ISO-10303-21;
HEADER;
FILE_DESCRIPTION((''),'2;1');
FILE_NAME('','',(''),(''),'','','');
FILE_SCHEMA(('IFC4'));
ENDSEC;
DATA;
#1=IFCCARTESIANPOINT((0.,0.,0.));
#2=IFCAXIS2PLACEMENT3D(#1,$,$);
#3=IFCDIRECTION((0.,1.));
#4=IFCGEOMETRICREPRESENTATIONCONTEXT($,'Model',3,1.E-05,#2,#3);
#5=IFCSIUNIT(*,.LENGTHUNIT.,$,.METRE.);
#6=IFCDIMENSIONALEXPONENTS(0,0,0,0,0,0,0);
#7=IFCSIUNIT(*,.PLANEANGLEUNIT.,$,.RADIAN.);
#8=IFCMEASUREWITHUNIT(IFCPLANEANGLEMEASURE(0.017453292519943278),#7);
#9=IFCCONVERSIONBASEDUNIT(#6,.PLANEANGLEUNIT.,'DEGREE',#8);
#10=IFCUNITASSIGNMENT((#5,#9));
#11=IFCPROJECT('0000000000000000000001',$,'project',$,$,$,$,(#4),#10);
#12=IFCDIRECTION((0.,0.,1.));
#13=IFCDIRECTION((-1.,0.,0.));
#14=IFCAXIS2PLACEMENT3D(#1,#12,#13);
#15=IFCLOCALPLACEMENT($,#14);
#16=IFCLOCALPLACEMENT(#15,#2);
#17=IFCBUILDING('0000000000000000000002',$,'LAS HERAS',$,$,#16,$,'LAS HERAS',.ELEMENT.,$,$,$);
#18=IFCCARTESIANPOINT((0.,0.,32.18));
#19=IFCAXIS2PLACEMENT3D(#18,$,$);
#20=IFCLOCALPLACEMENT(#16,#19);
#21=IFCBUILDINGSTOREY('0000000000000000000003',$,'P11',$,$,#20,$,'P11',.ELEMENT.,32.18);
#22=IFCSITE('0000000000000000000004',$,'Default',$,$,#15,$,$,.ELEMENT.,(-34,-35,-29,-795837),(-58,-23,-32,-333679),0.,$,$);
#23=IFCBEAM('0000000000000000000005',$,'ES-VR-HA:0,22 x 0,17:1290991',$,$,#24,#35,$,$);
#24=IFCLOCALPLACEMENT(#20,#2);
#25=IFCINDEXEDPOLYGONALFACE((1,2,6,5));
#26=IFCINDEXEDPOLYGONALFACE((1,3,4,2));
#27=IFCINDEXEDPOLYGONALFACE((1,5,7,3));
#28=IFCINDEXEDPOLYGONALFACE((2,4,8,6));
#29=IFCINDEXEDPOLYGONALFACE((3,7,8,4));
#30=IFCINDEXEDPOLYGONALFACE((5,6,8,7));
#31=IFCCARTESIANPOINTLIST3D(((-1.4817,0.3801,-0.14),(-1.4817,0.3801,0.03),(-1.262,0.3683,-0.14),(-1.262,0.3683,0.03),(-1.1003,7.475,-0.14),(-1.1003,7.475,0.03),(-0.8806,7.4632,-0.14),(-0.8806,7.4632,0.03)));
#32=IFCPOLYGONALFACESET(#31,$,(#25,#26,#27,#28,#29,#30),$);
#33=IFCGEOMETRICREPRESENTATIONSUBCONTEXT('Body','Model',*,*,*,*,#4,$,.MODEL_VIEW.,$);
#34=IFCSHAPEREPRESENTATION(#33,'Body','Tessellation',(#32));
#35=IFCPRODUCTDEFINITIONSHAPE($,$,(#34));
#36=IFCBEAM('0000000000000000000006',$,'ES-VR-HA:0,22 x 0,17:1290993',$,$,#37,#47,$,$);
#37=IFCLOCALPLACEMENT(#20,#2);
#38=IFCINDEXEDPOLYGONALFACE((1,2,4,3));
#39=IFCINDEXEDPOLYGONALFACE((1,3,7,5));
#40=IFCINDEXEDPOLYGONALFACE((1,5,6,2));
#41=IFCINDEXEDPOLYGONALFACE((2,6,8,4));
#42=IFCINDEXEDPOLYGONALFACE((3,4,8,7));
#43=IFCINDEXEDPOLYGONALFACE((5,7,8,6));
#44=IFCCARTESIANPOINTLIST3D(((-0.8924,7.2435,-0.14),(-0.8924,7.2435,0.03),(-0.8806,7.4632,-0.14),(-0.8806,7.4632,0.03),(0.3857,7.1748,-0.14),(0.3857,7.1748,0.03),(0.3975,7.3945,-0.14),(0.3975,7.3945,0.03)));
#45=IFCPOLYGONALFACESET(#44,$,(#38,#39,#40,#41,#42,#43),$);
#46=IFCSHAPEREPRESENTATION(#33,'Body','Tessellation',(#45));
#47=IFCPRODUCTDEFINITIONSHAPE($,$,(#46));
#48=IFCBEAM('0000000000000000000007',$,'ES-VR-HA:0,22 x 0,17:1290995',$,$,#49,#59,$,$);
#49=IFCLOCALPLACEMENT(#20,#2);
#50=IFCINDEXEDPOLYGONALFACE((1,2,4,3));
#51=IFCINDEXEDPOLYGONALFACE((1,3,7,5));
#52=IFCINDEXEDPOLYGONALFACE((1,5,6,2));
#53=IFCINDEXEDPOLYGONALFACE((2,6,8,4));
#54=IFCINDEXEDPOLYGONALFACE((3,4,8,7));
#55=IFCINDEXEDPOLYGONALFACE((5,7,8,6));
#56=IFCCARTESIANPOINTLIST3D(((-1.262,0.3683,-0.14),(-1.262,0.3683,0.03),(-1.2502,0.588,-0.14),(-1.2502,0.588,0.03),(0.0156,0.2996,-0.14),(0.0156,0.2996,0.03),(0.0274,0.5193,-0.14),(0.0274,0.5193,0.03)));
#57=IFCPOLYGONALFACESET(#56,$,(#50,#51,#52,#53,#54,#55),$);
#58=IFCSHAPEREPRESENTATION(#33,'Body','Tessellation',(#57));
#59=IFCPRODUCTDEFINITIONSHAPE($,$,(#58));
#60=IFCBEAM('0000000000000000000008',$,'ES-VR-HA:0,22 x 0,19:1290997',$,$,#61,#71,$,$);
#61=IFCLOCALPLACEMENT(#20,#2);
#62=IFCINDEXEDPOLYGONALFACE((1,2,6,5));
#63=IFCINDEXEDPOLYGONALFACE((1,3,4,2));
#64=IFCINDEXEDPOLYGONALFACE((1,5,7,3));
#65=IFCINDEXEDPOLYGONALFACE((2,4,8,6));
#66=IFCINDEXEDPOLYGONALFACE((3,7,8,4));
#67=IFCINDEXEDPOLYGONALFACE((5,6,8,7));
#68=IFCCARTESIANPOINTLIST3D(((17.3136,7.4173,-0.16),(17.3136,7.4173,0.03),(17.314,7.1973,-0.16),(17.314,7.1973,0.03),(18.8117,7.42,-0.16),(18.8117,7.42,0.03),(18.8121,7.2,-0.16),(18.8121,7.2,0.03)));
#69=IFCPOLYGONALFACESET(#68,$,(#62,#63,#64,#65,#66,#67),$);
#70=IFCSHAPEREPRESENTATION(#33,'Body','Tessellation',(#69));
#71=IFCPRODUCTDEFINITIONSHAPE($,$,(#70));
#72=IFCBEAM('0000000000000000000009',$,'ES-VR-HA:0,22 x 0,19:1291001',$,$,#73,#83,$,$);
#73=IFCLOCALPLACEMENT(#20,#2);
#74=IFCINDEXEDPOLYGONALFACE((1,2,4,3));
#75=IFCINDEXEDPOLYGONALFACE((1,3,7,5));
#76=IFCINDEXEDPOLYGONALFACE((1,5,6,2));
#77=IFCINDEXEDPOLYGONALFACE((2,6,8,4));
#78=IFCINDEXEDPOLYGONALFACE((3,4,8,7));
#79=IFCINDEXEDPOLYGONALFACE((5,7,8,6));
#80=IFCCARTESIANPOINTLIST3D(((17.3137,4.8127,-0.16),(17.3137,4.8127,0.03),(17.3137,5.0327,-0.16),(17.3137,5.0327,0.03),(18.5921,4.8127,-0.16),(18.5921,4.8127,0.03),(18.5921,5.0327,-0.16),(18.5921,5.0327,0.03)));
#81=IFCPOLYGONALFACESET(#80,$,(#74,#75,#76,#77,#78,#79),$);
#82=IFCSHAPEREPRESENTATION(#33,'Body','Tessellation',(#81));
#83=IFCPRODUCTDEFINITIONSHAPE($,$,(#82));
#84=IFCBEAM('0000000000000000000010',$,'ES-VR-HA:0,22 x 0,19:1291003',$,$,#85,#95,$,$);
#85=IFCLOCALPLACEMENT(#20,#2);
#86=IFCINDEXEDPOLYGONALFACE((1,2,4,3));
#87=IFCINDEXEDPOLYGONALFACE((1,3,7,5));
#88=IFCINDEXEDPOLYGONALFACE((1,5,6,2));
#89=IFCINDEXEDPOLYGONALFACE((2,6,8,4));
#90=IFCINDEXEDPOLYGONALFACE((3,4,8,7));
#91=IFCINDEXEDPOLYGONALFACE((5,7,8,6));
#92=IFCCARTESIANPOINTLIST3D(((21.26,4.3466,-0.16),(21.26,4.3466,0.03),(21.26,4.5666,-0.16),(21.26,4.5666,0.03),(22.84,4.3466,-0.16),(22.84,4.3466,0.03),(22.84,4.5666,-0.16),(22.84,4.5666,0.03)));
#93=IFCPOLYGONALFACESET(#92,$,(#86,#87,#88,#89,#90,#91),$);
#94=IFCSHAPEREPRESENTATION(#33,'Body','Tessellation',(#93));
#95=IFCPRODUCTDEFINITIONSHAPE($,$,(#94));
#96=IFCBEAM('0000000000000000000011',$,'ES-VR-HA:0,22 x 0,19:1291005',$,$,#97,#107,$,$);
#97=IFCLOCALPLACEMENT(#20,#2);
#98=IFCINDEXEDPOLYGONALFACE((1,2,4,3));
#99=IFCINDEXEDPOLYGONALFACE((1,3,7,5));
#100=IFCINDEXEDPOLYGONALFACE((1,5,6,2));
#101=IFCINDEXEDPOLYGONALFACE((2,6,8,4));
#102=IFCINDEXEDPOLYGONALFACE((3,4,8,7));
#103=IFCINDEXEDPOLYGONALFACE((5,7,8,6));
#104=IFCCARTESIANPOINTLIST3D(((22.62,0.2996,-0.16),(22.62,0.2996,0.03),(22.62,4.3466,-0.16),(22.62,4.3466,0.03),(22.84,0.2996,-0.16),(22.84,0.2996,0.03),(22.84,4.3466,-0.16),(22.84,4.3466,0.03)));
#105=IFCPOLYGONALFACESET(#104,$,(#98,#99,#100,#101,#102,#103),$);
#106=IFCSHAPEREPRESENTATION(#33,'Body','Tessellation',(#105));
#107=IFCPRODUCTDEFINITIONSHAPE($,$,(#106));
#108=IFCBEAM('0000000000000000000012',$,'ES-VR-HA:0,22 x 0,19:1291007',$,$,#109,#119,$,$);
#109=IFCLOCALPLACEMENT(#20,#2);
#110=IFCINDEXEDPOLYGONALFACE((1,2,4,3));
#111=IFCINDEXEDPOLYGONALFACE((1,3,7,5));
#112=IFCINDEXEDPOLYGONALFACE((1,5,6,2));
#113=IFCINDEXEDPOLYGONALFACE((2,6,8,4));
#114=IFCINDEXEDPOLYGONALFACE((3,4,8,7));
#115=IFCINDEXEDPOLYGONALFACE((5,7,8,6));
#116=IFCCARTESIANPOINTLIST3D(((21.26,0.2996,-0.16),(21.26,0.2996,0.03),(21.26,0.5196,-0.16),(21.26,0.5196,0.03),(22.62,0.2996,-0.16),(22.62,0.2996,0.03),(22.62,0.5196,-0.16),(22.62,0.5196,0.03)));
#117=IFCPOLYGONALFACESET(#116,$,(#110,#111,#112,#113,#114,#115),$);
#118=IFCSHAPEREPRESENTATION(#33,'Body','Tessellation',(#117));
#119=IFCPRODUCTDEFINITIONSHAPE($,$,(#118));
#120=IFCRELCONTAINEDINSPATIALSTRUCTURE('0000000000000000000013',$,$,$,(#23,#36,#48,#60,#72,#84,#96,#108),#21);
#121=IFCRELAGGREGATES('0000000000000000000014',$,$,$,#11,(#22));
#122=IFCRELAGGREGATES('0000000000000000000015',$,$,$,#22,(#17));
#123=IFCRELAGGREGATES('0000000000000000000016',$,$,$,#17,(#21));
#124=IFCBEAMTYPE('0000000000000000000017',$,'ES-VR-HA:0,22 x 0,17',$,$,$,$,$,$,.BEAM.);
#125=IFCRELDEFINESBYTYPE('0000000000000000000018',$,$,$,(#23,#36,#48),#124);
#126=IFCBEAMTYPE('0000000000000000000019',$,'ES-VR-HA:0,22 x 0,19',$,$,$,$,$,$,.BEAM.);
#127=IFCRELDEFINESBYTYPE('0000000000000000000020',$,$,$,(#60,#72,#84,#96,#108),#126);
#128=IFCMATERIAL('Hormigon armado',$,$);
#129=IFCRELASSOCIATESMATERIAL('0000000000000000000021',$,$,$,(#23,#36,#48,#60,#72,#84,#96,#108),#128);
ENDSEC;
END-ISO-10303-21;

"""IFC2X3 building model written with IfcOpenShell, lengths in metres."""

from ifc_helpers import new_model, entity, si_unit, converted_unit, direction, frame, frame_2d, origin, origin_2d_with_axis, place, context, subcontext, project, spatial, rectangle, extrude, material, type_object, element, save


model = new_model("IFC2X3")

# Units and contexts
model_context = context("Model", 3, precision=1e-05, world=origin(), true_north=direction((0.0, 1.0)))
body_context = subcontext(model_context, "Body", "Model", "MODEL_VIEW")
ifc_project = project(units=[si_unit("LENGTHUNIT", "METRE"), converted_unit("PLANEANGLEUNIT", "DEGREE", entity("IfcPlaneAngleMeasure", 0.017453292519943278), si_unit("PLANEANGLEUNIT", "RADIAN"), dimensions=[0, 0, 0, 0, 0, 0, 0])], contexts=[model_context])

# Site, building, storey
site_placement = place(None, frame((0.0, 0.0, 0.0), z_axis=(0.0, 0.0, 1.0), x_axis=(-1.0, 0.0, 0.0)))
site = spatial("IfcSite", under=ifc_project, at=site_placement, Name="Default", CompositionType="ELEMENT", RefLatitude=(-34, -35, -29, -795837), RefLongitude=(-58, -23, -32, -333679), RefElevation=0.0)
building_placement = place(site_placement, origin())
building = spatial("IfcBuilding", under=site, at=building_placement, Name="LAS HERAS", LongName="LAS HERAS", CompositionType="ELEMENT")
storey_placement = place(building_placement, frame((0.0, 0.0, 32.18)))
storey = spatial("IfcBuildingStorey", under=building, at=storey_placement, Name="P11", LongName="P11", CompositionType="ELEMENT", Elevation=32.18)

# Beams
ifc_material = material(Name="Hormigon armado")
beam_type_1 = type_object("IfcBeamType", Name="ES-VR-HA:0,22 x 0,17", PredefinedType="BEAM")
beam_1_placement = place(storey_placement, frame((-0.9963, 7.3593, 0.03), z_axis=(0.0, 0.0, 1.0), x_axis=(-0.05369, -0.998558, 0.0)))
element("IfcBeam", 1, at=beam_1_placement, inside=storey, type_object=beam_type_1, material=ifc_material, Name="ES-VR-HA:0,22 x 0,17:1290991", context=body_context, shape_type="SweptSolid", body=[
    extrude(rectangle(XDim=0.17, YDim=0.22, at=frame_2d((0.0, 0.0), x_axis=(1.0, 0.0))), frame((-0.11, 0.0, -0.085), z_axis=(1.0, 0.0, 0.0), x_axis=(0.0, 0.0, -1.0)), (0.0, 0.0, 1.0), 7.1052),
])
beam_2_placement = place(storey_placement, frame((0.3916, 7.2846, 0.03), z_axis=(0.0, 0.0, 1.0), x_axis=(-0.998558, 0.05368, 0.0)))
element("IfcBeam", 2, at=beam_2_placement, inside=storey, type_object=beam_type_1, material=ifc_material, Name="ES-VR-HA:0,22 x 0,17:1290993", context=body_context, shape_type="SweptSolid", body=[
    extrude(rectangle(XDim=0.17, YDim=0.22, at=frame_2d((0.0, 0.0), x_axis=(1.0, 0.0))), frame((0.0, 0.0, -0.085), z_axis=(1.0, 0.0, 0.0), x_axis=(0.0, 0.0, -1.0)), (0.0, 0.0, 1.0), 1.28),
])
beam_3_placement = place(storey_placement, frame((0.0215, 0.4094, 0.03), z_axis=(0.0, 0.0, 1.0), x_axis=(-0.998558, 0.05369, 0.0)))
element("IfcBeam", 3, at=beam_3_placement, inside=storey, type_object=beam_type_1, material=ifc_material, Name="ES-VR-HA:0,22 x 0,17:1290995", context=body_context, shape_type="SweptSolid", body=[
    extrude(rectangle(XDim=0.17, YDim=0.22, at=frame_2d((0.0, 0.0), x_axis=(1.0, 0.0))), frame((0.0, 0.0, -0.085), z_axis=(1.0, 0.0, 0.0), x_axis=(0.0, 0.0, -1.0)), (0.0, 0.0, 1.0), 1.2795),
])
beam_type_2 = type_object("IfcBeamType", Name="ES-VR-HA:0,22 x 0,19", PredefinedType="BEAM")
beam_4_placement = place(storey_placement, frame((17.3138, 7.3073, 0.03), z_axis=(0.0, 0.0, 1.0), x_axis=(0.999998, 0.001781, 0.0)))
element("IfcBeam", 4, at=beam_4_placement, inside=storey, type_object=beam_type_2, material=ifc_material, Name="ES-VR-HA:0,22 x 0,19:1290997", context=body_context, shape_type="SweptSolid", body=[
    extrude(rectangle(XDim=0.19, YDim=0.22, at=frame_2d((0.0, 0.0), x_axis=(1.0, 0.0))), frame((0.0, 0.0, -0.095), z_axis=(1.0, 0.0, 0.0), x_axis=(0.0, 0.0, -1.0)), (0.0, 0.0, 1.0), 1.4981),
])
beam_5_placement = place(storey_placement, frame((17.3137, 4.9227, 0.03)))
element("IfcBeam", 5, at=beam_5_placement, inside=storey, type_object=beam_type_2, material=ifc_material, Name="ES-VR-HA:0,22 x 0,19:1291001", context=body_context, shape_type="SweptSolid", body=[
    extrude(rectangle(XDim=0.19, YDim=0.22, at=frame_2d((0.0, 0.0), x_axis=(1.0, 0.0))), frame((0.0, 0.0, -0.095), z_axis=(1.0, 0.0, 0.0), x_axis=(0.0, 0.0, -1.0)), (0.0, 0.0, 1.0), 1.2784),
])
beam_6_placement = place(storey_placement, frame((21.26, 4.4566, 0.03)))
element("IfcBeam", 6, at=beam_6_placement, inside=storey, type_object=beam_type_2, material=ifc_material, Name="ES-VR-HA:0,22 x 0,19:1291003", context=body_context, shape_type="SweptSolid", body=[
    extrude(rectangle(XDim=0.19, YDim=0.22, at=origin_2d_with_axis()), frame((0.0, 0.0, -0.095), z_axis=(1.0, 0.0, 0.0), x_axis=(0.0, 0.0, -1.0)), (0.0, 0.0, 1.0), 1.58),
])
beam_7_placement = place(storey_placement, frame((22.73, 4.4566, 0.03), z_axis=(0.0, 0.0, 1.0), x_axis=(0.0, -1.0, 0.0)))
element("IfcBeam", 7, at=beam_7_placement, inside=storey, type_object=beam_type_2, material=ifc_material, Name="ES-VR-HA:0,22 x 0,19:1291005", context=body_context, shape_type="SweptSolid", body=[
    extrude(rectangle(XDim=0.19, YDim=0.22, at=frame_2d((0.0, 0.0), x_axis=(1.0, 0.0))), frame((0.11, 0.0, -0.095), z_axis=(1.0, 0.0, 0.0), x_axis=(0.0, 0.0, -1.0)), (0.0, 0.0, 1.0), 4.0471),
])
beam_8_placement = place(storey_placement, frame((21.26, 0.4096, 0.03)))
element("IfcBeam", 8, at=beam_8_placement, inside=storey, type_object=beam_type_2, material=ifc_material, Name="ES-VR-HA:0,22 x 0,19:1291007", context=body_context, shape_type="SweptSolid", body=[
    extrude(rectangle(XDim=0.19, YDim=0.22, at=frame_2d((0.0, 0.0), x_axis=(1.0, 0.0))), frame((0.0, 0.0, -0.095), z_axis=(1.0, 0.0, 0.0), x_axis=(0.0, 0.0, -1.0)), (0.0, 0.0, 1.0), 1.36),
])

save(model, "model.ifc")
